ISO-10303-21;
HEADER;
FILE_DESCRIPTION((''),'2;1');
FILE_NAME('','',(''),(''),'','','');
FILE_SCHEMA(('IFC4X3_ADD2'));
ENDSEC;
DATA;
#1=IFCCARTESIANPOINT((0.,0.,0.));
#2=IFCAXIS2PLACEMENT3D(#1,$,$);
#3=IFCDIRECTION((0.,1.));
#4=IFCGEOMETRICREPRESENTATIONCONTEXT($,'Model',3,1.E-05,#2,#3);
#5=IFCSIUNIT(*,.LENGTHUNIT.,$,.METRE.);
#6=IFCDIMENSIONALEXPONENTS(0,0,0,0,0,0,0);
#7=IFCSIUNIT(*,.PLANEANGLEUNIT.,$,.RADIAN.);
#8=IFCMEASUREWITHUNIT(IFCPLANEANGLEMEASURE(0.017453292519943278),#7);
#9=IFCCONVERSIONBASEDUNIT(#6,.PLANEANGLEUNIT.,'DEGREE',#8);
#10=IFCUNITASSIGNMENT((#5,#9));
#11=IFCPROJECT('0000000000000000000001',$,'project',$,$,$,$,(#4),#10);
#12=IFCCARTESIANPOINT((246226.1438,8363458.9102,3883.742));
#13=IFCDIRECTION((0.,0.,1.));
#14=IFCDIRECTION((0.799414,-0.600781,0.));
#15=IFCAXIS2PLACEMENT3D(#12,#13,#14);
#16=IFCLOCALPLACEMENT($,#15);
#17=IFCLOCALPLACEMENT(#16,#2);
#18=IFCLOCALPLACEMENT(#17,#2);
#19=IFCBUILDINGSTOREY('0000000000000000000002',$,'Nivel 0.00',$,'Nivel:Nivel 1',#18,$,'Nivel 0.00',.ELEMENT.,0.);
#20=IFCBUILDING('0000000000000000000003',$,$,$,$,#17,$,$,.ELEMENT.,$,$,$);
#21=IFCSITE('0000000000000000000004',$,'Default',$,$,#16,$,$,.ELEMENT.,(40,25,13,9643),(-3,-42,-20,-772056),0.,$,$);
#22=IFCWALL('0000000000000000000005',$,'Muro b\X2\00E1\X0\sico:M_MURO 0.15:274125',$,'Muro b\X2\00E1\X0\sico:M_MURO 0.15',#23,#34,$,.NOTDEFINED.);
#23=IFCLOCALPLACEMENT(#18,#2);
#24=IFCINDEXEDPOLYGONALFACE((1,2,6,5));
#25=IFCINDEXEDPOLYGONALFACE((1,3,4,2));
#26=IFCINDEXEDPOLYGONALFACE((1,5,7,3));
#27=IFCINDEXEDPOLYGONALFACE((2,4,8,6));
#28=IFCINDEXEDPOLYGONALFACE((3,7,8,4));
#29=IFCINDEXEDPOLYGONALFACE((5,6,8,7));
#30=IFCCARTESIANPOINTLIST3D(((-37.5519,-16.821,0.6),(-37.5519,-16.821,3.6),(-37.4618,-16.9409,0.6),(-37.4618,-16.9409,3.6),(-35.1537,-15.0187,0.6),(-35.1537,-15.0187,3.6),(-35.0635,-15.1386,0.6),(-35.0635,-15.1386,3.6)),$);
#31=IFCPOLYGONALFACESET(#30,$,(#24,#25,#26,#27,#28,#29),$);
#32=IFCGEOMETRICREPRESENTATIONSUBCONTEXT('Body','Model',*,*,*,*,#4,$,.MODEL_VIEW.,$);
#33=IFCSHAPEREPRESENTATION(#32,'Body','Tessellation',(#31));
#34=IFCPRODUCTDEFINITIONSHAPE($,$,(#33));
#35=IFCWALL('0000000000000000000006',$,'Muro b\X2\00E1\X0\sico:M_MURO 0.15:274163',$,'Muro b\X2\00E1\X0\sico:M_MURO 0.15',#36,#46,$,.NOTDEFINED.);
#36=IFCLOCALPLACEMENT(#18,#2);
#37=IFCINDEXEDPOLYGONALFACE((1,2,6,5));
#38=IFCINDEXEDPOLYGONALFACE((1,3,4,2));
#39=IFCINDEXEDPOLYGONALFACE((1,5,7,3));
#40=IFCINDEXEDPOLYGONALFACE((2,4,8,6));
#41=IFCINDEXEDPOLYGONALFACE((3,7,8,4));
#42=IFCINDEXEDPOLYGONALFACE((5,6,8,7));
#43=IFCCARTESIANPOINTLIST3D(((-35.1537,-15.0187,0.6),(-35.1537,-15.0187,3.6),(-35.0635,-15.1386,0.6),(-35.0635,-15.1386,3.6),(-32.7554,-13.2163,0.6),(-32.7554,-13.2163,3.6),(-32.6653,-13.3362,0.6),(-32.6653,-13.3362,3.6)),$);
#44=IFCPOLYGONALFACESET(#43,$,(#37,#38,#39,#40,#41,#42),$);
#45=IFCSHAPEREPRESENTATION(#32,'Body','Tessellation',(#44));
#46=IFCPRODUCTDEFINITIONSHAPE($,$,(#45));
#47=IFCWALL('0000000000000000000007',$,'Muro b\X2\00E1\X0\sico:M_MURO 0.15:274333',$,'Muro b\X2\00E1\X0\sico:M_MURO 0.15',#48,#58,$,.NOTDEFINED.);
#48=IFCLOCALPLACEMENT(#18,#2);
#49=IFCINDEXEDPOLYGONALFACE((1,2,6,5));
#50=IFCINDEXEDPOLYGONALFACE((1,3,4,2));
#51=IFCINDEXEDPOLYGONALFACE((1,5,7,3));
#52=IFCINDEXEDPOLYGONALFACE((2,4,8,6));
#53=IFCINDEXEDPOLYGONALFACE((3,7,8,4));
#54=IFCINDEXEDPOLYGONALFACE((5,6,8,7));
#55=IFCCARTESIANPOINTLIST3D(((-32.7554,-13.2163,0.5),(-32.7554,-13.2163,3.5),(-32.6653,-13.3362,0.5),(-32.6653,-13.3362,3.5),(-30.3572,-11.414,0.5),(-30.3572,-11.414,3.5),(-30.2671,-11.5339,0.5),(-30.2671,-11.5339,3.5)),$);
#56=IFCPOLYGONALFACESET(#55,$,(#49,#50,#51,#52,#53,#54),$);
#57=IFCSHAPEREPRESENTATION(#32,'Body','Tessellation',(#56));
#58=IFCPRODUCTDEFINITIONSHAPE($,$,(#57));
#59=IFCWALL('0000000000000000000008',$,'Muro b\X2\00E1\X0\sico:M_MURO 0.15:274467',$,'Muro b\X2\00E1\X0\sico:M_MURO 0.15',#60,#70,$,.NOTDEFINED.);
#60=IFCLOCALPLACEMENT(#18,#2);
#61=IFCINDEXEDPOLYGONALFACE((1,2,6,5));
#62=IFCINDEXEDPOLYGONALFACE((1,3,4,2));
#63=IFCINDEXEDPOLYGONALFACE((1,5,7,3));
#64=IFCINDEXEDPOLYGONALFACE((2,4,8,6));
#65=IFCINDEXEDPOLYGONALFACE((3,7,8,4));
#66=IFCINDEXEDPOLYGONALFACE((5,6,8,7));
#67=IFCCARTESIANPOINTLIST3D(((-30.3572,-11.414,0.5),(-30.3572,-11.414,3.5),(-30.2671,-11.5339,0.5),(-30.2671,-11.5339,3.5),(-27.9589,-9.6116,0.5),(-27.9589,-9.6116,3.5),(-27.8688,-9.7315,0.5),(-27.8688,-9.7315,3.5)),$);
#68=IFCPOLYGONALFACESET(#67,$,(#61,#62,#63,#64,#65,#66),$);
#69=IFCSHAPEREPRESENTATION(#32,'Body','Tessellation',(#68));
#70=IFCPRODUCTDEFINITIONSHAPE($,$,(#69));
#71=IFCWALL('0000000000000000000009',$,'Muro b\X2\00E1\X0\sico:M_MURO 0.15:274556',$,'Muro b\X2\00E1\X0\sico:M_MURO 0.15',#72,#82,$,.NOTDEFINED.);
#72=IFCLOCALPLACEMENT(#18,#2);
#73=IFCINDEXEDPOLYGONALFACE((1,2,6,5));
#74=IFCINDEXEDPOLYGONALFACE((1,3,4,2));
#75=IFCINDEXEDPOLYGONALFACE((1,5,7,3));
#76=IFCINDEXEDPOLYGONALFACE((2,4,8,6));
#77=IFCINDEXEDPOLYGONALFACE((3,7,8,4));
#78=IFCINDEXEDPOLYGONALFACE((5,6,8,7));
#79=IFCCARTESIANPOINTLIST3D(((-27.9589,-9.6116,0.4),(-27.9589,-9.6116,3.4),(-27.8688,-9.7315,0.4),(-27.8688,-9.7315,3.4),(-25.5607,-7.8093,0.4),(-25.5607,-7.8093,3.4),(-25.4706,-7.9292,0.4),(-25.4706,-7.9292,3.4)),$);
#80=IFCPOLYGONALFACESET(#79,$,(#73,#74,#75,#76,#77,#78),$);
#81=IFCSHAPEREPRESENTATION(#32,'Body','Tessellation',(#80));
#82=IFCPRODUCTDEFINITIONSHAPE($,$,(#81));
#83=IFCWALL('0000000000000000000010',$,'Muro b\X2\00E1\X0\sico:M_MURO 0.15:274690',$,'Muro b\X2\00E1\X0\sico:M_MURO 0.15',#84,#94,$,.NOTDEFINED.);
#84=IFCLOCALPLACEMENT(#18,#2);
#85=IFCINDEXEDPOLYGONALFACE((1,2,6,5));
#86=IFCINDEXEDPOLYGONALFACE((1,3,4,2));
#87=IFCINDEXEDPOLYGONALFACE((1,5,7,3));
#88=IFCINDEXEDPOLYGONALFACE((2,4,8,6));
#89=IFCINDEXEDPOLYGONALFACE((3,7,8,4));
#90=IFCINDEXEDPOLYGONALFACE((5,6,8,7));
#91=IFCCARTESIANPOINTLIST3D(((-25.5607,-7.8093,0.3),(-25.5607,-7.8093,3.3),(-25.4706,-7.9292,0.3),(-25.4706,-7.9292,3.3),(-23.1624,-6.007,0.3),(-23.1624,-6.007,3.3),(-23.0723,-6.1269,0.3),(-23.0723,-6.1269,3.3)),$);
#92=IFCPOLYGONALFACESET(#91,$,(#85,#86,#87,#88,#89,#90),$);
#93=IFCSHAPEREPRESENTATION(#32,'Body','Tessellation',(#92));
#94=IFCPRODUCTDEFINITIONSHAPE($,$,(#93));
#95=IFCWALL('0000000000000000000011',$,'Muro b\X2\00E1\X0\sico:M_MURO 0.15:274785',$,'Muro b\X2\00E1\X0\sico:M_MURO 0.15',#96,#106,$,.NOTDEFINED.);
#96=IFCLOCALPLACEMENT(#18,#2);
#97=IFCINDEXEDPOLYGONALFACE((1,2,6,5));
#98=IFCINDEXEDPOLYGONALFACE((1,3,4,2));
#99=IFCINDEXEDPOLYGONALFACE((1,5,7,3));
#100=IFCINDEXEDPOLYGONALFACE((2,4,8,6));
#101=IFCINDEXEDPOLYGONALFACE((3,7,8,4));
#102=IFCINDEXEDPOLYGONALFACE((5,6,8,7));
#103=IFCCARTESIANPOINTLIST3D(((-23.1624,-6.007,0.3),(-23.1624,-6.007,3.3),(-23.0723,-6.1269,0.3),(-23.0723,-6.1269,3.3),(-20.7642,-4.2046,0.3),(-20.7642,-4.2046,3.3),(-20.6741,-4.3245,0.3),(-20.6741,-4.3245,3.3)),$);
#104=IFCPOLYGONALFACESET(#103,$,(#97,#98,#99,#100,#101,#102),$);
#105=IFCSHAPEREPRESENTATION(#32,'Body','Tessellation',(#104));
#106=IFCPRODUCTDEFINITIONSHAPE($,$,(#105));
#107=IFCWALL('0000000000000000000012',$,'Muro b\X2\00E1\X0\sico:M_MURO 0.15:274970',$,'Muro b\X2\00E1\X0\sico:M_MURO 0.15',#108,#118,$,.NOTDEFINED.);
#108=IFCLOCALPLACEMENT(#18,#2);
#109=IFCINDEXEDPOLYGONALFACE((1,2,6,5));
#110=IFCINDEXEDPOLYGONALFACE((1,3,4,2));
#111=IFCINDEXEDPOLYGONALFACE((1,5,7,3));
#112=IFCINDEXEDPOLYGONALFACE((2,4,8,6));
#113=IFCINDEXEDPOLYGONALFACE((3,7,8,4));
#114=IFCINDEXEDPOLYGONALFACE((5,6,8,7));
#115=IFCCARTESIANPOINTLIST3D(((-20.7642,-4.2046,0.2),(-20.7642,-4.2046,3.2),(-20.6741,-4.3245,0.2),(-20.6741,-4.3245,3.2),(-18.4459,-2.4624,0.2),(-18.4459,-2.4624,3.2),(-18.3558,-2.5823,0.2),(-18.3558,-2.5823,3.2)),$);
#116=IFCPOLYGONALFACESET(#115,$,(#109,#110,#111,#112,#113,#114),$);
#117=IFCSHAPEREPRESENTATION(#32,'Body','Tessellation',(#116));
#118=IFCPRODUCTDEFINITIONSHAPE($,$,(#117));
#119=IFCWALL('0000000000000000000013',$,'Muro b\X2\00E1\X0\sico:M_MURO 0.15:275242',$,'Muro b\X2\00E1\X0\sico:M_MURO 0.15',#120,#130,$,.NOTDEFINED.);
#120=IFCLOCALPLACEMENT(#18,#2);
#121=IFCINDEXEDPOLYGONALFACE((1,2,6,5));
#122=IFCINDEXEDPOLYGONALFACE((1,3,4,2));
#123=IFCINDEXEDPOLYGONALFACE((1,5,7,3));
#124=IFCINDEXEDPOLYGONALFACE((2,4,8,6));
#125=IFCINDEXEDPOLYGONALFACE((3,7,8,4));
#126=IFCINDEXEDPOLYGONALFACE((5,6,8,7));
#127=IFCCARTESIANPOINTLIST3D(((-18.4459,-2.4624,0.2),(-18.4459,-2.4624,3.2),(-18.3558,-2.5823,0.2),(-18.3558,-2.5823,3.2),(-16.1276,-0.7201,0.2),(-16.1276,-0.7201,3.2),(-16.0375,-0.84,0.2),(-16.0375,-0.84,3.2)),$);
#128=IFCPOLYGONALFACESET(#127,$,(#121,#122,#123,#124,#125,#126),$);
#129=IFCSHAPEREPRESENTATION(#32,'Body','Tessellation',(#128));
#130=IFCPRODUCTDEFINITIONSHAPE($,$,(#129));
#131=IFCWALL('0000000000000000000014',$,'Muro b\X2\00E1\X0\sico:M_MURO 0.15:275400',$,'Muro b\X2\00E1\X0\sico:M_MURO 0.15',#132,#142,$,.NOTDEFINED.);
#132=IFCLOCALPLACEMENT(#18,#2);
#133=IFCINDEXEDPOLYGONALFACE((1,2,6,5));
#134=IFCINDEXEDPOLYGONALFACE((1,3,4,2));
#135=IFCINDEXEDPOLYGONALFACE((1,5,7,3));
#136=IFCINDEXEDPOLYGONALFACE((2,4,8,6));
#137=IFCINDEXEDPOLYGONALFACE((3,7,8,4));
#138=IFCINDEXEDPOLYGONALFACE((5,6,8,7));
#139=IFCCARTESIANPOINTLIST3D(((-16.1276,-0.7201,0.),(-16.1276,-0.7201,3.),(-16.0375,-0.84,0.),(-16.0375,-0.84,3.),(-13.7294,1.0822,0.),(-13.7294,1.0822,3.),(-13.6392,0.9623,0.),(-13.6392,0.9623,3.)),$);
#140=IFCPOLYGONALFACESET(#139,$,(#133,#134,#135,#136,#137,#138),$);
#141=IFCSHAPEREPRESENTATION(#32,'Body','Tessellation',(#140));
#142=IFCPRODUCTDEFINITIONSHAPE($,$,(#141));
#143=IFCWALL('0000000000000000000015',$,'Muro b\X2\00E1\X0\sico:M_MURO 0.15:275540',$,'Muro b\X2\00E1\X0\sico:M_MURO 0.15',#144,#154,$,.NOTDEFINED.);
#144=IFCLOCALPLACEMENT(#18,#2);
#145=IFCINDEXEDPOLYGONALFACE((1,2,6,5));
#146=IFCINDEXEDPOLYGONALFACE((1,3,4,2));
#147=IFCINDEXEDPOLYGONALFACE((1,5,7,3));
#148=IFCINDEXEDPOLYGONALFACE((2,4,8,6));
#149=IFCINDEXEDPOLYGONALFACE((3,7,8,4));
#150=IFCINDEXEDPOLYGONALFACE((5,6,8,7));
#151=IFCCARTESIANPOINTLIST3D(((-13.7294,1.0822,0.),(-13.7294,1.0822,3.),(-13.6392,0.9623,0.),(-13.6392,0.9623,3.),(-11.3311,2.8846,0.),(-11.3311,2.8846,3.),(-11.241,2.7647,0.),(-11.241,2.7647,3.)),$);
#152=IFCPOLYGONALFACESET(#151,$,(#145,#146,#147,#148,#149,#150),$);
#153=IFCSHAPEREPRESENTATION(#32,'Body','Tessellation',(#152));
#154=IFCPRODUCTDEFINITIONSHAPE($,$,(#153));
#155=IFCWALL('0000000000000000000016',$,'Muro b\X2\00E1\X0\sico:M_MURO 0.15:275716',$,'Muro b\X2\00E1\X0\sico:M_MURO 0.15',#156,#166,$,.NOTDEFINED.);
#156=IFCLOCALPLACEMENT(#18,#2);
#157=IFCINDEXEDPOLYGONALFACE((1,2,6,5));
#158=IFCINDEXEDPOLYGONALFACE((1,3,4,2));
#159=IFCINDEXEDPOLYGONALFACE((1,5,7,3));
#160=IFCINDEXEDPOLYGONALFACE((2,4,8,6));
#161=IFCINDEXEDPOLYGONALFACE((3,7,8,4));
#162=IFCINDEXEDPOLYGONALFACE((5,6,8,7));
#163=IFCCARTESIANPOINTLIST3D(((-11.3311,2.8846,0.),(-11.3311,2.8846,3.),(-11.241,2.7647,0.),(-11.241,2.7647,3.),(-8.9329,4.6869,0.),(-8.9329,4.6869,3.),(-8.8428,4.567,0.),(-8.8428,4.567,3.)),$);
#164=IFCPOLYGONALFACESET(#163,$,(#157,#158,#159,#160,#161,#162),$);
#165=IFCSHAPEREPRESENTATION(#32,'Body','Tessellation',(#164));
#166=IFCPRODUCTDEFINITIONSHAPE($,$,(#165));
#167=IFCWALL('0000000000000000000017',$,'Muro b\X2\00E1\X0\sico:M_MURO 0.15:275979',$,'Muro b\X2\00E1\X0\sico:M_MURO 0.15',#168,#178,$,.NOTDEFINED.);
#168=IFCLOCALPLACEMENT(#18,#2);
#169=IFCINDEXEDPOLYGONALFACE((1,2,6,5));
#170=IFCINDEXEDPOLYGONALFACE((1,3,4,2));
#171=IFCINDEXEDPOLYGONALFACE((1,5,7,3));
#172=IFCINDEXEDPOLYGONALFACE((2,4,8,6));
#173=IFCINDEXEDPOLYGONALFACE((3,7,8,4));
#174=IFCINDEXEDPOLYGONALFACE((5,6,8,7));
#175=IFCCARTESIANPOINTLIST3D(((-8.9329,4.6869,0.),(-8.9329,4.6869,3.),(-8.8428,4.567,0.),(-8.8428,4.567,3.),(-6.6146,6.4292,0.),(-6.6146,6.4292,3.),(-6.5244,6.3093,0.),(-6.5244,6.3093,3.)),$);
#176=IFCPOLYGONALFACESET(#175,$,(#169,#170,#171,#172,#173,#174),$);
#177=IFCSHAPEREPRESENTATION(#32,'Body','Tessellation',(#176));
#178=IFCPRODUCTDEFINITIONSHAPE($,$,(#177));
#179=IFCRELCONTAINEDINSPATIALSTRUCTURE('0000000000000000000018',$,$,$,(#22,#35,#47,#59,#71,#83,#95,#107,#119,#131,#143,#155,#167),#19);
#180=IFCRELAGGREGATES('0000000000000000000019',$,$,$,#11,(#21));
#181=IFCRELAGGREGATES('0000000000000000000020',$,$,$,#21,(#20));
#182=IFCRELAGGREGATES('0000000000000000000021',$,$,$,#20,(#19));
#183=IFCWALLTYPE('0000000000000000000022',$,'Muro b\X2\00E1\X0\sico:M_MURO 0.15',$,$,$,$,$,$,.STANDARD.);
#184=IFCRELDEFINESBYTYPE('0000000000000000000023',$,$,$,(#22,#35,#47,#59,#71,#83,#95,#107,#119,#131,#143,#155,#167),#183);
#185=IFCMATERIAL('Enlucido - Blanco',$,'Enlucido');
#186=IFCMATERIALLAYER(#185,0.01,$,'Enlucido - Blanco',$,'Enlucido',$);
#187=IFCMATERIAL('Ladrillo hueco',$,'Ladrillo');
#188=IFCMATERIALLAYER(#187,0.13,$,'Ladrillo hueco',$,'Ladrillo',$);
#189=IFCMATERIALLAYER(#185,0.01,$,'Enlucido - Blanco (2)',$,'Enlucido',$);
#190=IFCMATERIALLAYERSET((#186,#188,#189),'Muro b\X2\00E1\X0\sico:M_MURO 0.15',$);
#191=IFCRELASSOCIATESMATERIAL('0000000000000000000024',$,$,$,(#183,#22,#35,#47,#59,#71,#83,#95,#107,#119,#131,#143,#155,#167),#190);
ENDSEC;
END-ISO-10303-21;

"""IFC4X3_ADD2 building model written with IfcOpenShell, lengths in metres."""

from ifc_helpers import new_model, entity, si_unit, converted_unit, direction, frame, frame_2d, origin, place, context, subcontext, project, spatial, rectangle, extrude, material, layer, layer_set, type_object, element, save


model = new_model("IFC4X3_ADD2")

# Units and contexts
model_context = context("Model", 3, precision=1e-05, world=origin(), true_north=direction((0.0, 1.0)))
body_context = subcontext(model_context, "Body", "Model", "MODEL_VIEW")
ifc_project = project(units=[si_unit("LENGTHUNIT", "METRE"), converted_unit("PLANEANGLEUNIT", "DEGREE", entity("IfcPlaneAngleMeasure", 0.017453292519943278), si_unit("PLANEANGLEUNIT", "RADIAN"), dimensions=[0, 0, 0, 0, 0, 0, 0])], contexts=[model_context])

# Site, building, storey
site_placement = place(None, frame((246226.1438, 8363458.9102, 3883.742), z_axis=(0.0, 0.0, 1.0), x_axis=(0.799414, -0.600781, 0.0)))
site = spatial("IfcSite", under=ifc_project, at=site_placement, Name="Default", CompositionType="ELEMENT", RefLatitude=(40, 25, 13, 9643), RefLongitude=(-3, -42, -20, -772056), RefElevation=0.0)
building_placement = place(site_placement, origin())
building = spatial("IfcBuilding", under=site, at=building_placement, CompositionType="ELEMENT")
storey_placement = place(building_placement, origin())
storey = spatial("IfcBuildingStorey", under=building, at=storey_placement, Name="Nivel 0.00", ObjectType="Nivel:Nivel 1", LongName="Nivel 0.00", CompositionType="ELEMENT", Elevation=0.0)

# Walls
ifc_material_1 = material(Name="Enlucido - Blanco", Category="Enlucido")
ifc_layer_1 = layer(ifc_material_1, 0.01, Name="Enlucido - Blanco", Category="Enlucido")
ifc_material_2 = material(Name="Ladrillo hueco", Category="Ladrillo")
ifc_layer_2 = layer(ifc_material_2, 0.13, Name="Ladrillo hueco", Category="Ladrillo")
ifc_layer_3 = layer(ifc_material_1, 0.01, Name="Enlucido - Blanco (2)", Category="Enlucido")
ifc_layer_set = layer_set([ifc_layer_1, ifc_layer_2, ifc_layer_3], Name="Muro básico:M_MURO 0.15")
wall_type = type_object("IfcWallType", Name="Muro básico:M_MURO 0.15", PredefinedType="STANDARD", material=ifc_layer_set)
wall_1_placement = place(storey_placement, frame((-37.5068, -16.881, 0.6), z_axis=(0.0, 0.0, 1.0), x_axis=(0.799414, 0.60078, 0.0)))
element("IfcWall", 1, at=wall_1_placement, inside=storey, type_object=wall_type, material=ifc_layer_set, Name="Muro básico:M_MURO 0.15:274125", ObjectType="Muro básico:M_MURO 0.15", PredefinedType="NOTDEFINED", context=body_context, shape_type="SweptSolid", body=[
    extrude(rectangle(XDim=3.0, YDim=0.15, at=frame_2d((1.5, 0.0), x_axis=(-1.0, 0.0))), origin(), (0.0, 0.0, 1.0), 3.0),
])
wall_2_placement = place(storey_placement, frame((-35.1086, -15.0786, 0.6), z_axis=(0.0, 0.0, 1.0), x_axis=(0.799414, 0.60078, 0.0)))
element("IfcWall", 2, at=wall_2_placement, inside=storey, type_object=wall_type, material=ifc_layer_set, Name="Muro básico:M_MURO 0.15:274163", ObjectType="Muro básico:M_MURO 0.15", PredefinedType="NOTDEFINED", context=body_context, shape_type="SweptSolid", body=[
    extrude(rectangle(XDim=3.0, YDim=0.15, at=frame_2d((1.5, 0.0), x_axis=(-1.0, 0.0))), origin(), (0.0, 0.0, 1.0), 3.0),
])
wall_3_placement = place(storey_placement, frame((-32.7104, -13.2763, 0.5), z_axis=(0.0, 0.0, 1.0), x_axis=(0.799414, 0.60078, 0.0)))
element("IfcWall", 3, at=wall_3_placement, inside=storey, type_object=wall_type, material=ifc_layer_set, Name="Muro básico:M_MURO 0.15:274333", ObjectType="Muro básico:M_MURO 0.15", PredefinedType="NOTDEFINED", context=body_context, shape_type="SweptSolid", body=[
    extrude(rectangle(XDim=3.0, YDim=0.15, at=frame_2d((1.5, 0.0), x_axis=(-1.0, 0.0))), origin(), (0.0, 0.0, 1.0), 3.0),
])
wall_4_placement = place(storey_placement, frame((-30.3121, -11.4739, 0.5), z_axis=(0.0, 0.0, 1.0), x_axis=(0.799414, 0.60078, 0.0)))
element("IfcWall", 4, at=wall_4_placement, inside=storey, type_object=wall_type, material=ifc_layer_set, Name="Muro básico:M_MURO 0.15:274467", ObjectType="Muro básico:M_MURO 0.15", PredefinedType="NOTDEFINED", context=body_context, shape_type="SweptSolid", body=[
    extrude(rectangle(XDim=3.0, YDim=0.15, at=frame_2d((1.5, 0.0), x_axis=(-1.0, 0.0))), origin(), (0.0, 0.0, 1.0), 3.0),
])
wall_5_placement = place(storey_placement, frame((-27.9139, -9.6716, 0.4), z_axis=(0.0, 0.0, 1.0), x_axis=(0.799414, 0.60078, 0.0)))
element("IfcWall", 5, at=wall_5_placement, inside=storey, type_object=wall_type, material=ifc_layer_set, Name="Muro básico:M_MURO 0.15:274556", ObjectType="Muro básico:M_MURO 0.15", PredefinedType="NOTDEFINED", context=body_context, shape_type="SweptSolid", body=[
    extrude(rectangle(XDim=3.0, YDim=0.15, at=frame_2d((1.5, 0.0), x_axis=(-1.0, 0.0))), origin(), (0.0, 0.0, 1.0), 3.0),
])
wall_6_placement = place(storey_placement, frame((-25.5156, -7.8693, 0.3), z_axis=(0.0, 0.0, 1.0), x_axis=(0.799414, 0.60078, 0.0)))
element("IfcWall", 6, at=wall_6_placement, inside=storey, type_object=wall_type, material=ifc_layer_set, Name="Muro básico:M_MURO 0.15:274690", ObjectType="Muro básico:M_MURO 0.15", PredefinedType="NOTDEFINED", context=body_context, shape_type="SweptSolid", body=[
    extrude(rectangle(XDim=3.0, YDim=0.15, at=frame_2d((1.5, 0.0), x_axis=(-1.0, 0.0))), origin(), (0.0, 0.0, 1.0), 3.0),
])
wall_7_placement = place(storey_placement, frame((-23.1174, -6.0669, 0.3), z_axis=(0.0, 0.0, 1.0), x_axis=(0.799414, 0.60078, 0.0)))
element("IfcWall", 7, at=wall_7_placement, inside=storey, type_object=wall_type, material=ifc_layer_set, Name="Muro básico:M_MURO 0.15:274785", ObjectType="Muro básico:M_MURO 0.15", PredefinedType="NOTDEFINED", context=body_context, shape_type="SweptSolid", body=[
    extrude(rectangle(XDim=3.0, YDim=0.15, at=frame_2d((1.5, 0.0), x_axis=(-1.0, 0.0))), origin(), (0.0, 0.0, 1.0), 3.0),
])
wall_8_placement = place(storey_placement, frame((-20.7191, -4.2646, 0.2), z_axis=(0.0, 0.0, 1.0), x_axis=(0.799414, 0.60078, 0.0)))
element("IfcWall", 8, at=wall_8_placement, inside=storey, type_object=wall_type, material=ifc_layer_set, Name="Muro básico:M_MURO 0.15:274970", ObjectType="Muro básico:M_MURO 0.15", PredefinedType="NOTDEFINED", context=body_context, shape_type="SweptSolid", body=[
    extrude(rectangle(XDim=2.9, YDim=0.15, at=frame_2d((1.45, 0.0), x_axis=(-1.0, 0.0))), origin(), (0.0, 0.0, 1.0), 3.0),
])
wall_9_placement = place(storey_placement, frame((-18.4008, -2.5223, 0.2), z_axis=(0.0, 0.0, 1.0), x_axis=(0.799414, 0.60078, 0.0)))
element("IfcWall", 9, at=wall_9_placement, inside=storey, type_object=wall_type, material=ifc_layer_set, Name="Muro básico:M_MURO 0.15:275242", ObjectType="Muro básico:M_MURO 0.15", PredefinedType="NOTDEFINED", context=body_context, shape_type="SweptSolid", body=[
    extrude(rectangle(XDim=2.9, YDim=0.15, at=frame_2d((1.45, 0.0), x_axis=(-1.0, 0.0))), origin(), (0.0, 0.0, 1.0), 3.0),
])
wall_10_placement = place(storey_placement, frame((-16.0825, -0.78, 0.0), z_axis=(0.0, 0.0, 1.0), x_axis=(0.799414, 0.60078, 0.0)))
element("IfcWall", 10, at=wall_10_placement, inside=storey, type_object=wall_type, material=ifc_layer_set, Name="Muro básico:M_MURO 0.15:275400", ObjectType="Muro básico:M_MURO 0.15", PredefinedType="NOTDEFINED", context=body_context, shape_type="SweptSolid", body=[
    extrude(rectangle(XDim=3.0, YDim=0.15, at=frame_2d((1.5, 0.0), x_axis=(-1.0, 0.0))), origin(), (0.0, 0.0, 1.0), 3.0),
])
wall_11_placement = place(storey_placement, frame((-13.6843, 1.0223, 0.0), z_axis=(0.0, 0.0, 1.0), x_axis=(0.799414, 0.60078, 0.0)))
element("IfcWall", 11, at=wall_11_placement, inside=storey, type_object=wall_type, material=ifc_layer_set, Name="Muro básico:M_MURO 0.15:275540", ObjectType="Muro básico:M_MURO 0.15", PredefinedType="NOTDEFINED", context=body_context, shape_type="SweptSolid", body=[
    extrude(rectangle(XDim=3.0, YDim=0.15, at=frame_2d((1.5, 0.0), x_axis=(-1.0, 0.0))), origin(), (0.0, 0.0, 1.0), 3.0),
])
wall_12_placement = place(storey_placement, frame((-11.2861, 2.8246, 0.0), z_axis=(0.0, 0.0, 1.0), x_axis=(0.799414, 0.60078, 0.0)))
element("IfcWall", 12, at=wall_12_placement, inside=storey, type_object=wall_type, material=ifc_layer_set, Name="Muro básico:M_MURO 0.15:275716", ObjectType="Muro básico:M_MURO 0.15", PredefinedType="NOTDEFINED", context=body_context, shape_type="SweptSolid", body=[
    extrude(rectangle(XDim=3.0, YDim=0.15, at=frame_2d((1.5, 0.0), x_axis=(-1.0, 0.0))), origin(), (0.0, 0.0, 1.0), 3.0),
])
wall_13_placement = place(storey_placement, frame((-8.8878, 4.627, 0.0), z_axis=(0.0, 0.0, 1.0), x_axis=(0.799414, 0.60078, 0.0)))
element("IfcWall", 13, at=wall_13_placement, inside=storey, type_object=wall_type, material=ifc_layer_set, Name="Muro básico:M_MURO 0.15:275979", ObjectType="Muro básico:M_MURO 0.15", PredefinedType="NOTDEFINED", context=body_context, shape_type="SweptSolid", body=[
    extrude(rectangle(XDim=2.9, YDim=0.15, at=frame_2d((1.45, 0.0), x_axis=(-1.0, 0.0))), origin(), (0.0, 0.0, 1.0), 3.0),
])

save(model, "model.ifc")
